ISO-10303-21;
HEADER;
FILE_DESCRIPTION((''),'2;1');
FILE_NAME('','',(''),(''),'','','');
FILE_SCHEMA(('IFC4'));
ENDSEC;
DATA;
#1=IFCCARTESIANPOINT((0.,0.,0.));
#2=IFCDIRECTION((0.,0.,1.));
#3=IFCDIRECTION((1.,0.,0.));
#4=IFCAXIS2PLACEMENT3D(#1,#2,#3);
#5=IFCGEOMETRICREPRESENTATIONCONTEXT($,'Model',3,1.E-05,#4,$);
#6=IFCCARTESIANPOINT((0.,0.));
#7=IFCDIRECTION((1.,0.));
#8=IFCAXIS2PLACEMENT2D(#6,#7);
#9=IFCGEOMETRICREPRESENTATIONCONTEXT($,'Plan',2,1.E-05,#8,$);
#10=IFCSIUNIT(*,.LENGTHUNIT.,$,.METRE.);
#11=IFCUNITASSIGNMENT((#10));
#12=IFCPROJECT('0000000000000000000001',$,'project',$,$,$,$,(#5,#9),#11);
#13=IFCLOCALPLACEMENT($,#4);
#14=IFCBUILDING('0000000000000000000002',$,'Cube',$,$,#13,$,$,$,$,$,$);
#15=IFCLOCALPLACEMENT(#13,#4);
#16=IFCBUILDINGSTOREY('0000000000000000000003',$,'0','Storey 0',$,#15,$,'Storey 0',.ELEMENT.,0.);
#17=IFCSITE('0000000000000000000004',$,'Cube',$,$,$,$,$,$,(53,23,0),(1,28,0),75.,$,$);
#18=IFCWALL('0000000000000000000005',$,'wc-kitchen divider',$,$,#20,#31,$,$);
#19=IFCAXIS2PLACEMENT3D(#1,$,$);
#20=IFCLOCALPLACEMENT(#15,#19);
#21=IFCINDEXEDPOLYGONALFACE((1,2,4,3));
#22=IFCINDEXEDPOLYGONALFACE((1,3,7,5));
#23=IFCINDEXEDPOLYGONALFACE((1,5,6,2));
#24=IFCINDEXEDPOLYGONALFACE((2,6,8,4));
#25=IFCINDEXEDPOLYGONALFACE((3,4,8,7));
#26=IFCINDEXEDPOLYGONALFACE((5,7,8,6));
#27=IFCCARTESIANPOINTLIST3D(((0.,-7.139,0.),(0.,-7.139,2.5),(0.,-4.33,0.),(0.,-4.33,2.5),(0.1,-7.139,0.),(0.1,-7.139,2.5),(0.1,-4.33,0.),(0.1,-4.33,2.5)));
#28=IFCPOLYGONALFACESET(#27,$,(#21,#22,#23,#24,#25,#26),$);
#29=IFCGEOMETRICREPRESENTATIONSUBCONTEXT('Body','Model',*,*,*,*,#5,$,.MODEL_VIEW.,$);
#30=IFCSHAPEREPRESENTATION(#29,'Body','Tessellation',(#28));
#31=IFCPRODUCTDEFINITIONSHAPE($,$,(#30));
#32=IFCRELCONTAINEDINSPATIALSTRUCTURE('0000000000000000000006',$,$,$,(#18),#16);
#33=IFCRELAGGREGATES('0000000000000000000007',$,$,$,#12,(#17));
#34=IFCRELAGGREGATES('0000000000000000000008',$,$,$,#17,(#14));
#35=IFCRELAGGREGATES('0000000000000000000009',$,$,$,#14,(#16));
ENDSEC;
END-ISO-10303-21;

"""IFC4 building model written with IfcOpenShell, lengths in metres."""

from ifc_helpers import new_model, si_unit, frame, origin_with_axes, origin_2d_with_axis, place, context, subcontext, project, spatial, indexed_curve, outline, extrude, element, save


model = new_model("IFC4")

# Units and contexts
model_context = context("Model", 3, precision=1e-05, world=origin_with_axes())
plan_context = context("Plan", 2, precision=1e-05, world=origin_2d_with_axis())
body_context = subcontext(model_context, "Body", "Model", "MODEL_VIEW")
ifc_project = project(units=[si_unit("LENGTHUNIT", "METRE")], contexts=[model_context, plan_context])

# Site, building, storey
site = spatial("IfcSite", under=ifc_project, Name="Cube", RefLatitude=(53, 23, 0), RefLongitude=(1, 28, 0), RefElevation=75.0)
building_placement = place(None, origin_with_axes())
building = spatial("IfcBuilding", under=site, at=building_placement, Name="Cube")
storey_placement = place(building_placement, origin_with_axes())
storey = spatial("IfcBuildingStorey", under=building, at=storey_placement, Name="0", Description="Storey 0", LongName="Storey 0", CompositionType="ELEMENT", Elevation=0.0)

# Wall
wall_1_placement = place(storey_placement, frame((0.0, -4.33, 0.0), z_axis=(0.0, 0.0, 1.0), x_axis=(0.0, -1.0, 0.0)))
element("IfcWall", 1, at=wall_1_placement, inside=storey, Name="wc-kitchen divider", context=body_context, shape_type="SweptSolid", body=[
    extrude(outline(indexed_curve([(0.0, 0.0), (0.0, 0.1), (2.809, 0.1), (2.809, 0.0), (0.0, 0.0)], self_intersect=False)), origin_with_axes(), (0.0, 0.0, 1.0), 2.5),
])

save(model, "model.ifc")
